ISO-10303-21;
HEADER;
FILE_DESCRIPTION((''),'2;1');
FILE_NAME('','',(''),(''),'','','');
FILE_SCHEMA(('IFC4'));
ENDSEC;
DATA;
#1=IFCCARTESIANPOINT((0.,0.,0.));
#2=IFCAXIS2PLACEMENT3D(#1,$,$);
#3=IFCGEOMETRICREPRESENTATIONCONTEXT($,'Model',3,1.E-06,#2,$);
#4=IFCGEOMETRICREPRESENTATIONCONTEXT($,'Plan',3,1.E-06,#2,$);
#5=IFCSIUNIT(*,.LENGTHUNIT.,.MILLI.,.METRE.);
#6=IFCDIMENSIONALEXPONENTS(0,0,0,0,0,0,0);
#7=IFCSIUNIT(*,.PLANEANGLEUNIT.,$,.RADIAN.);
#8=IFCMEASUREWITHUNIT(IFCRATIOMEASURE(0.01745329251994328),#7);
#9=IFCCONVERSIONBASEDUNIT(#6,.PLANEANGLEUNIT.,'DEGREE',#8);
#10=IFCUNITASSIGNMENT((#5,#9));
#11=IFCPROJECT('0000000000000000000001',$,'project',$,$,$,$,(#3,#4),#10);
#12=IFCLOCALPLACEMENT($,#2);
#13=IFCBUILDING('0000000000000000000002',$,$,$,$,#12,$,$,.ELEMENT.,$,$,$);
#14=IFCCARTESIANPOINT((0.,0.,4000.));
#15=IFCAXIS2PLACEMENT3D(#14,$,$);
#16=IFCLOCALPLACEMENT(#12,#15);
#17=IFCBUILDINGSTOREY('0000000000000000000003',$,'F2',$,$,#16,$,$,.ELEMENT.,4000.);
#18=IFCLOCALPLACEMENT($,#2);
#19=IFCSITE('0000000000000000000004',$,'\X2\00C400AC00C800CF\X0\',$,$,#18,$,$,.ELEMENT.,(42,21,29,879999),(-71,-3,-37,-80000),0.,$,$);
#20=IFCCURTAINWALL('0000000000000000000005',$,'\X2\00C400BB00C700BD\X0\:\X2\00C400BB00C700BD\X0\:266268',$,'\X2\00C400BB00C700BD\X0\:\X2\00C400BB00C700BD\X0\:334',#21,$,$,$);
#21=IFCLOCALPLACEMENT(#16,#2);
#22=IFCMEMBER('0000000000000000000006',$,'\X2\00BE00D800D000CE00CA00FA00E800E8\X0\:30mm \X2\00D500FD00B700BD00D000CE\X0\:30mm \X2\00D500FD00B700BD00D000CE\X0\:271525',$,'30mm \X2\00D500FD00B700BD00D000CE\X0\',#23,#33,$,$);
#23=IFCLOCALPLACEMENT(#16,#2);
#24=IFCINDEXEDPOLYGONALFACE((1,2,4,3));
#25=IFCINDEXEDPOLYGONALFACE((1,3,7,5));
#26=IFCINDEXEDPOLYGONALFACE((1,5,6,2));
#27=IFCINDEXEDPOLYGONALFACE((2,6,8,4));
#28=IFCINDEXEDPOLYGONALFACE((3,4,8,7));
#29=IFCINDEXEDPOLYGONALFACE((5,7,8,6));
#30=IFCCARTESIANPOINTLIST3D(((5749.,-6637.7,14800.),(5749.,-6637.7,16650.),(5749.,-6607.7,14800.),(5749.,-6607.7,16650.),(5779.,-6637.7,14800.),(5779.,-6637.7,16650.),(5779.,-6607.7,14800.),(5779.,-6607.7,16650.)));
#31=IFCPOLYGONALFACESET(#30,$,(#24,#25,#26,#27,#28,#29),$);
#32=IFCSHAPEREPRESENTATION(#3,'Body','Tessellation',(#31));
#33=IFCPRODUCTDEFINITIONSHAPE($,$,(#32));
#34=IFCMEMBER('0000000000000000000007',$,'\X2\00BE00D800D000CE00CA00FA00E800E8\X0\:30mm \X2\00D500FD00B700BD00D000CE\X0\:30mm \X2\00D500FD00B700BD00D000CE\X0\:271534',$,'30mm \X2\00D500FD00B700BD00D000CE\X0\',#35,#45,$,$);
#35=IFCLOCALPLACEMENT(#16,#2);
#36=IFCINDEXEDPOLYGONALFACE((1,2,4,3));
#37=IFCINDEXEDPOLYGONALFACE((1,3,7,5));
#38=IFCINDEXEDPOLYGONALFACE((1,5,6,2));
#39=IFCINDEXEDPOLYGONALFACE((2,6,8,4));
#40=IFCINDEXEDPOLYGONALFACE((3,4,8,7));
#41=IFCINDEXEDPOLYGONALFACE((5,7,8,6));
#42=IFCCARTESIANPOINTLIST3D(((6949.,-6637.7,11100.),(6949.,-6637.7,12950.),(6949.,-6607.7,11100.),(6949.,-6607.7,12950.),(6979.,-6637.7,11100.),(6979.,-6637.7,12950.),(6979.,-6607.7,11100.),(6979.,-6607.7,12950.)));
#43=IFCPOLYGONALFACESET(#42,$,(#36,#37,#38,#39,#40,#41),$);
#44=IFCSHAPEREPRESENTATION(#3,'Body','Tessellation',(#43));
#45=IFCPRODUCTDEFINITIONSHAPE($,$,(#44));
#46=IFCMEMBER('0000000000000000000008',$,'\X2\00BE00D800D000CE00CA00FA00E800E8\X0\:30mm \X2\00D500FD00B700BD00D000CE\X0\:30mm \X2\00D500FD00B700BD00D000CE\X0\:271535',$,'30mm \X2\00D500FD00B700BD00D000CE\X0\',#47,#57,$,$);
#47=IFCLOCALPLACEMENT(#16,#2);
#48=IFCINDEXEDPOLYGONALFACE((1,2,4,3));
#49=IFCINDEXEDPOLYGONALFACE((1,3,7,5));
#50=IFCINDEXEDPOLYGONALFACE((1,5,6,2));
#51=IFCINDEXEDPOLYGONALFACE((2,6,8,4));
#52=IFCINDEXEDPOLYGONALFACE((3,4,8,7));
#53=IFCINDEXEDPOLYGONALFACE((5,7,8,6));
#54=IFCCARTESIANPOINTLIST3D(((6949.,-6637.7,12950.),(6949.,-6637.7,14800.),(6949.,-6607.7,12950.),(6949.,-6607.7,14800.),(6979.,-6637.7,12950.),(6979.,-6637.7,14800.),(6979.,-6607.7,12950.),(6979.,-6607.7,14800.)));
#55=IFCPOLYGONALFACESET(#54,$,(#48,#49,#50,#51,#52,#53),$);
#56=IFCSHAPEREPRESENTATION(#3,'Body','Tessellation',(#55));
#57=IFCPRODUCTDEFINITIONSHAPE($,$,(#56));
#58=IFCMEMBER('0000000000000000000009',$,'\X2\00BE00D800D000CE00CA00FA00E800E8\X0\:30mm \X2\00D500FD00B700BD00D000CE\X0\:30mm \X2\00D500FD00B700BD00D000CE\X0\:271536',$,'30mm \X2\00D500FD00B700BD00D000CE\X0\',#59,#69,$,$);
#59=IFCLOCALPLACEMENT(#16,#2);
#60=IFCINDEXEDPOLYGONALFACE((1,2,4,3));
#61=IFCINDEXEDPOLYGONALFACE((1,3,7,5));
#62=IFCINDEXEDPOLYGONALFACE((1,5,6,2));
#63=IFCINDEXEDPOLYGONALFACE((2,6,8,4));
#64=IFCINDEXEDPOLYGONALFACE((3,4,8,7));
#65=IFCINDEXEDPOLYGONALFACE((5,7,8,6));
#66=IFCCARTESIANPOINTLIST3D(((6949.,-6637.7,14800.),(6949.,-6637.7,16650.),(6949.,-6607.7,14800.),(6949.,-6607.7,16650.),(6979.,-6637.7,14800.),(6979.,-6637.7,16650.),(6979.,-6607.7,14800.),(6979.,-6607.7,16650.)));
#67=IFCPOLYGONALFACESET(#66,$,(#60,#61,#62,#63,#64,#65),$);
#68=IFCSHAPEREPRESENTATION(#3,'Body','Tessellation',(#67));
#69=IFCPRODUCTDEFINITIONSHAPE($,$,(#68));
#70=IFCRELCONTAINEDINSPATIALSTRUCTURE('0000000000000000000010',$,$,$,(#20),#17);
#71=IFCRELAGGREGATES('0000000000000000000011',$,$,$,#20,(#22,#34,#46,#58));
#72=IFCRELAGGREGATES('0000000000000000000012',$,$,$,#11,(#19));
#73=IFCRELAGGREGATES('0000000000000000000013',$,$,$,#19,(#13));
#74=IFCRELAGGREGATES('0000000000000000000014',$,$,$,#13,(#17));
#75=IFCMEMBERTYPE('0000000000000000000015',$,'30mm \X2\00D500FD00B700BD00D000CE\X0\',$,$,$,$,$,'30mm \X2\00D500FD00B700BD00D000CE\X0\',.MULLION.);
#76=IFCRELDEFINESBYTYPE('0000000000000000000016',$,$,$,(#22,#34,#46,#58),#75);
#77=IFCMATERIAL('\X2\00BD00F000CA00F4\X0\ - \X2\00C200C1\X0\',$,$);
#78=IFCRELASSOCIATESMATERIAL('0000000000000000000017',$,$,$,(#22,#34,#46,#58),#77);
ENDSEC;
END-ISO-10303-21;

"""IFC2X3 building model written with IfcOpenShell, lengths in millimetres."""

from ifc_helpers import new_model, entity, si_unit, converted_unit, frame, origin, origin_2d_with_axis, place, context, project, spatial, rectangle, extrude, source, transform, mapped, material, type_object, type_shapes, element, aggregate, save


model = new_model("IFC2X3")

# Units and contexts
model_context = context("Model", 3, precision=1e-06, world=origin())
plan_context = context("Plan", 3, precision=1e-06, world=origin())
ifc_project = project(units=[si_unit("LENGTHUNIT", "METRE", prefix="MILLI"), converted_unit("PLANEANGLEUNIT", "DEGREE", entity("IfcRatioMeasure", 0.01745329251994328), si_unit("PLANEANGLEUNIT", "RADIAN"), dimensions=[0, 0, 0, 0, 0, 0, 0])], contexts=[model_context, plan_context])

# Site, building, storey
site_placement = place(None, origin())
site = spatial("IfcSite", under=ifc_project, at=site_placement, Name="Ä¬ÈÏ", CompositionType="ELEMENT", RefLatitude=(42, 21, 29, 879999), RefLongitude=(-71, -3, -37, -80000), RefElevation=0.0)
building_placement = place(None, origin())
building = spatial("IfcBuilding", under=site, at=building_placement, CompositionType="ELEMENT")
storey_placement = place(building_placement, frame((0.0, 0.0, 4000.0)))
storey = spatial("IfcBuildingStorey", under=building, at=storey_placement, Name="F2", CompositionType="ELEMENT", Elevation=4000.0)

# Curtain wall, members
curtain_wall_placement = place(storey_placement, origin())
curtain_wall = element("IfcCurtainWall", 1, at=curtain_wall_placement, inside=storey, Name="Ä»Ç½:Ä»Ç½:266268", ObjectType="Ä»Ç½:Ä»Ç½:334")
ifc_material_1 = material(Name="½ðÊô - ÂÁ")
placement_1 = place(building_placement, frame((0.0, 0.0, 15100.0)))
placement_2 = place(building_placement, frame((0.0, 0.0, 18800.0)))
member_type_1 = type_object("IfcMemberType", Name="30mm Õý·½ÐÎ", ElementType="30mm Õý·½ÐÎ", PredefinedType="MULLION")
shared_shape_1 = source(origin(), model_context, "Body", "SweptSolid", [
    extrude(rectangle(XDim=30.0, YDim=30.0, at=origin_2d_with_axis()), frame((0.0, 0.0, -1850.0), z_axis=(0.0, 0.0, 1.0), x_axis=(-1.0, 0.0, 0.0)), (0.0, 0.0, 1.0), 1850.0),
])
type_shapes(member_type_1, [shared_shape_1])
member_1_placement = place(placement_2, frame((5764.0, -6622.7, 0.0), z_axis=(0.0, 0.0, -1.0), x_axis=(1.0, 0.0, 0.0)))
member_1 = element("IfcMember", 2, at=member_1_placement, type_object=member_type_1, material=ifc_material_1, Name="¾ØÐÎÊúèè:30mm Õý·½ÐÎ:30mm Õý·½ÐÎ:271525", ObjectType="30mm Õý·½ÐÎ", context=model_context, shape_type="MappedRepresentation", body=[
    mapped(shared_shape_1, transform((0.0, 0.0, 0.0), scale=1.0)),
])
member_2_placement = place(placement_1, frame((6964.0, -6622.7, 0.0), z_axis=(0.0, 0.0, -1.0), x_axis=(1.0, 0.0, 0.0)))
member_2 = element("IfcMember", 3, at=member_2_placement, type_object=member_type_1, material=ifc_material_1, Name="¾ØÐÎÊúèè:30mm Õý·½ÐÎ:30mm Õý·½ÐÎ:271534", ObjectType="30mm Õý·½ÐÎ", context=model_context, shape_type="MappedRepresentation", body=[
    mapped(shared_shape_1, transform((0.0, 0.0, 0.0), scale=1.0)),
])
member_3_placement = place(placement_1, frame((6964.0, -6622.7, 1850.0), z_axis=(0.0, 0.0, -1.0), x_axis=(1.0, 0.0, 0.0)))
member_3 = element("IfcMember", 4, at=member_3_placement, type_object=member_type_1, material=ifc_material_1, Name="¾ØÐÎÊúèè:30mm Õý·½ÐÎ:30mm Õý·½ÐÎ:271535", ObjectType="30mm Õý·½ÐÎ", context=model_context, shape_type="MappedRepresentation", body=[
    mapped(shared_shape_1, transform((0.0, 0.0, 0.0), scale=1.0)),
])
member_4_placement = place(placement_2, frame((6964.0, -6622.7, 0.0), z_axis=(0.0, 0.0, -1.0), x_axis=(1.0, 0.0, 0.0)))
member_4 = element("IfcMember", 5, at=member_4_placement, type_object=member_type_1, material=ifc_material_1, Name="¾ØÐÎÊúèè:30mm Õý·½ÐÎ:30mm Õý·½ÐÎ:271536", ObjectType="30mm Õý·½ÐÎ", context=model_context, shape_type="MappedRepresentation", body=[
    mapped(shared_shape_1, transform((0.0, 0.0, 0.0), scale=1.0)),
])
aggregate(curtain_wall, [member_1, member_2, member_3, member_4])

save(model, "model.ifc")
